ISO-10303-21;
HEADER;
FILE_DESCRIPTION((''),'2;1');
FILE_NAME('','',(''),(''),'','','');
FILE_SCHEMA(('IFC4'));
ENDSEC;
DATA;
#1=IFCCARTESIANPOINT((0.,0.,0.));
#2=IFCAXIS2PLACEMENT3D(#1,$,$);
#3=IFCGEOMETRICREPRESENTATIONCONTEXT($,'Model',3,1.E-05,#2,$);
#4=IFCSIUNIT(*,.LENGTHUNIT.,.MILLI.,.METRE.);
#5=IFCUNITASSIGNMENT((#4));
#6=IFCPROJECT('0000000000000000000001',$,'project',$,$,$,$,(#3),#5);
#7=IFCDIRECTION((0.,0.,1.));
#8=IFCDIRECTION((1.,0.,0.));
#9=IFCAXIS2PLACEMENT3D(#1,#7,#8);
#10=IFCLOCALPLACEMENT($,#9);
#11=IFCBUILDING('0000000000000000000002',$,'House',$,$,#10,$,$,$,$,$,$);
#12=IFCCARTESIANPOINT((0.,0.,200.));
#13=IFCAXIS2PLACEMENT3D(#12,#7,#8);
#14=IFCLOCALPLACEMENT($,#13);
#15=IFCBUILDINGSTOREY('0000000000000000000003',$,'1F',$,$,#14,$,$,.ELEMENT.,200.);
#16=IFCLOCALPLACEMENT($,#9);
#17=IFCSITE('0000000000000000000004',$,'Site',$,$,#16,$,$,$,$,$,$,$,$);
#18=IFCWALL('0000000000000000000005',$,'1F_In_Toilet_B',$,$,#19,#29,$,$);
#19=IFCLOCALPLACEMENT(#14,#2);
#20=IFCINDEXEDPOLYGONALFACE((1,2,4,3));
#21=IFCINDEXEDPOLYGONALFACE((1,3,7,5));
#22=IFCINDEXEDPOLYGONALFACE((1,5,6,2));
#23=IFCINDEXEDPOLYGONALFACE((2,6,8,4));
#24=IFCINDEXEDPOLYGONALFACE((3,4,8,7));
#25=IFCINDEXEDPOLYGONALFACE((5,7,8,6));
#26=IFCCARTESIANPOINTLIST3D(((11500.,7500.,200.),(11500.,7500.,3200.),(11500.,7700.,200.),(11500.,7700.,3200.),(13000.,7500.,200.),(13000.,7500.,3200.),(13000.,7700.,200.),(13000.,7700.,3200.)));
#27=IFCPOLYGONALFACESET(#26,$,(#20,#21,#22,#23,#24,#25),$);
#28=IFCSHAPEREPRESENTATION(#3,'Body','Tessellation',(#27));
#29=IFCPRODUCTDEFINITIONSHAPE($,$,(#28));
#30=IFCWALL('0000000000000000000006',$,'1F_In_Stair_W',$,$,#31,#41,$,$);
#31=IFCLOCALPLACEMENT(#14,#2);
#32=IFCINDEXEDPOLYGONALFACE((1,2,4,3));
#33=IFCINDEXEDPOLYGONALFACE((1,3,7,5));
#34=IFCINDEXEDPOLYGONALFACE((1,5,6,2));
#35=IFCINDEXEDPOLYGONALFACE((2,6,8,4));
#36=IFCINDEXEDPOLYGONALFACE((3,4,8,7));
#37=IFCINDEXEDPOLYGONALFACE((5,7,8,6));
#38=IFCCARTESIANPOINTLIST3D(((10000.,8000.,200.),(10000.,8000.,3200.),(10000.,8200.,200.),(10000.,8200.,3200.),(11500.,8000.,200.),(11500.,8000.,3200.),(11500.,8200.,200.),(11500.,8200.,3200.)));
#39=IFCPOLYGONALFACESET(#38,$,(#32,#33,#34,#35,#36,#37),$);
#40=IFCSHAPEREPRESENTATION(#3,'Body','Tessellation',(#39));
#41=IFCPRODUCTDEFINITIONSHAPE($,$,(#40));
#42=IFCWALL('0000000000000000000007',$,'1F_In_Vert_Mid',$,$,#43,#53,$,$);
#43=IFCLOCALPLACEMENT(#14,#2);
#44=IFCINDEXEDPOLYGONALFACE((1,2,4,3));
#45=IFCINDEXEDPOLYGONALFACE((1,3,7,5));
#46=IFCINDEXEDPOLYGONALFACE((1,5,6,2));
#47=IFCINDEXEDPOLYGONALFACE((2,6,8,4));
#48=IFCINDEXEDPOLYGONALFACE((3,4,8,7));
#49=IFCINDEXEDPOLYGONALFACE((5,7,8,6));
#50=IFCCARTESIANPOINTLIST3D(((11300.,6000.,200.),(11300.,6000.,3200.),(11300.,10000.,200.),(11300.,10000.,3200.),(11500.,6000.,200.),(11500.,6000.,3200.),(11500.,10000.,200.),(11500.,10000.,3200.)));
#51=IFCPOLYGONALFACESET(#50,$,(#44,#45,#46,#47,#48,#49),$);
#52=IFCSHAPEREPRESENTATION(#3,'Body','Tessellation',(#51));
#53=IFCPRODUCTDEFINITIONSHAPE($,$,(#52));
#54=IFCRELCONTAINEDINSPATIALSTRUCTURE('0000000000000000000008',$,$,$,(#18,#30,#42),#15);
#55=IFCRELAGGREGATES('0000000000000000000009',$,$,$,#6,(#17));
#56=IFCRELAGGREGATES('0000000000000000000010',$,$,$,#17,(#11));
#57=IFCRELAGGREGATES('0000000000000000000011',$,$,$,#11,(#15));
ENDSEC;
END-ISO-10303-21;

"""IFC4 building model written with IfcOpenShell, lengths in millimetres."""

from ifc_helpers import new_model, si_unit, frame, origin, origin_with_axes, place, context, project, spatial, rectangle, extrude, element, save


model = new_model("IFC4")

# Units and contexts
model_context = context("Model", 3, precision=1e-05, world=origin())
ifc_project = project(units=[si_unit("LENGTHUNIT", "METRE", prefix="MILLI")], contexts=[model_context])

# Site, building, storey
site_placement = place(None, origin_with_axes())
site = spatial("IfcSite", under=ifc_project, at=site_placement, Name="Site")
building_placement = place(None, origin_with_axes())
building = spatial("IfcBuilding", under=site, at=building_placement, Name="House")
storey_placement = place(None, frame((0.0, 0.0, 200.0), z_axis=(0.0, 0.0, 1.0), x_axis=(1.0, 0.0, 0.0)))
storey = spatial("IfcBuildingStorey", under=building, at=storey_placement, Name="1F", CompositionType="ELEMENT", Elevation=200.0)

# Walls
for number, where, z_axis, x_axis, name in (
    (1, (11500.0, 7500.0, 400.0), (0.0, 0.0, 1.0), (1.0, 0.0, 0.0), "1F_In_Toilet_B"),
    (2, (10000.0, 8000.0, 400.0), (0.0, 0.0, 1.0), (1.0, 0.0, 0.0), "1F_In_Stair_W"),
):
    element("IfcWall", number, at=place(None, frame(where, z_axis=z_axis, x_axis=x_axis)), inside=storey, Name=name, context=model_context, shape_type="SweptSolid", body=[
        extrude(rectangle(XDim=1500.0, YDim=200.0), frame((750.0, 100.0, 0.0)), (0.0, 0.0, 1.0), 3000.0),
    ])
wall_1_placement = place(None, frame((11300.0, 6000.0, 400.0), z_axis=(0.0, 0.0, 1.0), x_axis=(1.0, 0.0, 0.0)))
element("IfcWall", 3, at=wall_1_placement, inside=storey, Name="1F_In_Vert_Mid", context=model_context, shape_type="SweptSolid", body=[
    extrude(rectangle(XDim=200.0, YDim=4000.0), frame((100.0, 2000.0, 0.0)), (0.0, 0.0, 1.0), 3000.0),
])

save(model, "model.ifc")
